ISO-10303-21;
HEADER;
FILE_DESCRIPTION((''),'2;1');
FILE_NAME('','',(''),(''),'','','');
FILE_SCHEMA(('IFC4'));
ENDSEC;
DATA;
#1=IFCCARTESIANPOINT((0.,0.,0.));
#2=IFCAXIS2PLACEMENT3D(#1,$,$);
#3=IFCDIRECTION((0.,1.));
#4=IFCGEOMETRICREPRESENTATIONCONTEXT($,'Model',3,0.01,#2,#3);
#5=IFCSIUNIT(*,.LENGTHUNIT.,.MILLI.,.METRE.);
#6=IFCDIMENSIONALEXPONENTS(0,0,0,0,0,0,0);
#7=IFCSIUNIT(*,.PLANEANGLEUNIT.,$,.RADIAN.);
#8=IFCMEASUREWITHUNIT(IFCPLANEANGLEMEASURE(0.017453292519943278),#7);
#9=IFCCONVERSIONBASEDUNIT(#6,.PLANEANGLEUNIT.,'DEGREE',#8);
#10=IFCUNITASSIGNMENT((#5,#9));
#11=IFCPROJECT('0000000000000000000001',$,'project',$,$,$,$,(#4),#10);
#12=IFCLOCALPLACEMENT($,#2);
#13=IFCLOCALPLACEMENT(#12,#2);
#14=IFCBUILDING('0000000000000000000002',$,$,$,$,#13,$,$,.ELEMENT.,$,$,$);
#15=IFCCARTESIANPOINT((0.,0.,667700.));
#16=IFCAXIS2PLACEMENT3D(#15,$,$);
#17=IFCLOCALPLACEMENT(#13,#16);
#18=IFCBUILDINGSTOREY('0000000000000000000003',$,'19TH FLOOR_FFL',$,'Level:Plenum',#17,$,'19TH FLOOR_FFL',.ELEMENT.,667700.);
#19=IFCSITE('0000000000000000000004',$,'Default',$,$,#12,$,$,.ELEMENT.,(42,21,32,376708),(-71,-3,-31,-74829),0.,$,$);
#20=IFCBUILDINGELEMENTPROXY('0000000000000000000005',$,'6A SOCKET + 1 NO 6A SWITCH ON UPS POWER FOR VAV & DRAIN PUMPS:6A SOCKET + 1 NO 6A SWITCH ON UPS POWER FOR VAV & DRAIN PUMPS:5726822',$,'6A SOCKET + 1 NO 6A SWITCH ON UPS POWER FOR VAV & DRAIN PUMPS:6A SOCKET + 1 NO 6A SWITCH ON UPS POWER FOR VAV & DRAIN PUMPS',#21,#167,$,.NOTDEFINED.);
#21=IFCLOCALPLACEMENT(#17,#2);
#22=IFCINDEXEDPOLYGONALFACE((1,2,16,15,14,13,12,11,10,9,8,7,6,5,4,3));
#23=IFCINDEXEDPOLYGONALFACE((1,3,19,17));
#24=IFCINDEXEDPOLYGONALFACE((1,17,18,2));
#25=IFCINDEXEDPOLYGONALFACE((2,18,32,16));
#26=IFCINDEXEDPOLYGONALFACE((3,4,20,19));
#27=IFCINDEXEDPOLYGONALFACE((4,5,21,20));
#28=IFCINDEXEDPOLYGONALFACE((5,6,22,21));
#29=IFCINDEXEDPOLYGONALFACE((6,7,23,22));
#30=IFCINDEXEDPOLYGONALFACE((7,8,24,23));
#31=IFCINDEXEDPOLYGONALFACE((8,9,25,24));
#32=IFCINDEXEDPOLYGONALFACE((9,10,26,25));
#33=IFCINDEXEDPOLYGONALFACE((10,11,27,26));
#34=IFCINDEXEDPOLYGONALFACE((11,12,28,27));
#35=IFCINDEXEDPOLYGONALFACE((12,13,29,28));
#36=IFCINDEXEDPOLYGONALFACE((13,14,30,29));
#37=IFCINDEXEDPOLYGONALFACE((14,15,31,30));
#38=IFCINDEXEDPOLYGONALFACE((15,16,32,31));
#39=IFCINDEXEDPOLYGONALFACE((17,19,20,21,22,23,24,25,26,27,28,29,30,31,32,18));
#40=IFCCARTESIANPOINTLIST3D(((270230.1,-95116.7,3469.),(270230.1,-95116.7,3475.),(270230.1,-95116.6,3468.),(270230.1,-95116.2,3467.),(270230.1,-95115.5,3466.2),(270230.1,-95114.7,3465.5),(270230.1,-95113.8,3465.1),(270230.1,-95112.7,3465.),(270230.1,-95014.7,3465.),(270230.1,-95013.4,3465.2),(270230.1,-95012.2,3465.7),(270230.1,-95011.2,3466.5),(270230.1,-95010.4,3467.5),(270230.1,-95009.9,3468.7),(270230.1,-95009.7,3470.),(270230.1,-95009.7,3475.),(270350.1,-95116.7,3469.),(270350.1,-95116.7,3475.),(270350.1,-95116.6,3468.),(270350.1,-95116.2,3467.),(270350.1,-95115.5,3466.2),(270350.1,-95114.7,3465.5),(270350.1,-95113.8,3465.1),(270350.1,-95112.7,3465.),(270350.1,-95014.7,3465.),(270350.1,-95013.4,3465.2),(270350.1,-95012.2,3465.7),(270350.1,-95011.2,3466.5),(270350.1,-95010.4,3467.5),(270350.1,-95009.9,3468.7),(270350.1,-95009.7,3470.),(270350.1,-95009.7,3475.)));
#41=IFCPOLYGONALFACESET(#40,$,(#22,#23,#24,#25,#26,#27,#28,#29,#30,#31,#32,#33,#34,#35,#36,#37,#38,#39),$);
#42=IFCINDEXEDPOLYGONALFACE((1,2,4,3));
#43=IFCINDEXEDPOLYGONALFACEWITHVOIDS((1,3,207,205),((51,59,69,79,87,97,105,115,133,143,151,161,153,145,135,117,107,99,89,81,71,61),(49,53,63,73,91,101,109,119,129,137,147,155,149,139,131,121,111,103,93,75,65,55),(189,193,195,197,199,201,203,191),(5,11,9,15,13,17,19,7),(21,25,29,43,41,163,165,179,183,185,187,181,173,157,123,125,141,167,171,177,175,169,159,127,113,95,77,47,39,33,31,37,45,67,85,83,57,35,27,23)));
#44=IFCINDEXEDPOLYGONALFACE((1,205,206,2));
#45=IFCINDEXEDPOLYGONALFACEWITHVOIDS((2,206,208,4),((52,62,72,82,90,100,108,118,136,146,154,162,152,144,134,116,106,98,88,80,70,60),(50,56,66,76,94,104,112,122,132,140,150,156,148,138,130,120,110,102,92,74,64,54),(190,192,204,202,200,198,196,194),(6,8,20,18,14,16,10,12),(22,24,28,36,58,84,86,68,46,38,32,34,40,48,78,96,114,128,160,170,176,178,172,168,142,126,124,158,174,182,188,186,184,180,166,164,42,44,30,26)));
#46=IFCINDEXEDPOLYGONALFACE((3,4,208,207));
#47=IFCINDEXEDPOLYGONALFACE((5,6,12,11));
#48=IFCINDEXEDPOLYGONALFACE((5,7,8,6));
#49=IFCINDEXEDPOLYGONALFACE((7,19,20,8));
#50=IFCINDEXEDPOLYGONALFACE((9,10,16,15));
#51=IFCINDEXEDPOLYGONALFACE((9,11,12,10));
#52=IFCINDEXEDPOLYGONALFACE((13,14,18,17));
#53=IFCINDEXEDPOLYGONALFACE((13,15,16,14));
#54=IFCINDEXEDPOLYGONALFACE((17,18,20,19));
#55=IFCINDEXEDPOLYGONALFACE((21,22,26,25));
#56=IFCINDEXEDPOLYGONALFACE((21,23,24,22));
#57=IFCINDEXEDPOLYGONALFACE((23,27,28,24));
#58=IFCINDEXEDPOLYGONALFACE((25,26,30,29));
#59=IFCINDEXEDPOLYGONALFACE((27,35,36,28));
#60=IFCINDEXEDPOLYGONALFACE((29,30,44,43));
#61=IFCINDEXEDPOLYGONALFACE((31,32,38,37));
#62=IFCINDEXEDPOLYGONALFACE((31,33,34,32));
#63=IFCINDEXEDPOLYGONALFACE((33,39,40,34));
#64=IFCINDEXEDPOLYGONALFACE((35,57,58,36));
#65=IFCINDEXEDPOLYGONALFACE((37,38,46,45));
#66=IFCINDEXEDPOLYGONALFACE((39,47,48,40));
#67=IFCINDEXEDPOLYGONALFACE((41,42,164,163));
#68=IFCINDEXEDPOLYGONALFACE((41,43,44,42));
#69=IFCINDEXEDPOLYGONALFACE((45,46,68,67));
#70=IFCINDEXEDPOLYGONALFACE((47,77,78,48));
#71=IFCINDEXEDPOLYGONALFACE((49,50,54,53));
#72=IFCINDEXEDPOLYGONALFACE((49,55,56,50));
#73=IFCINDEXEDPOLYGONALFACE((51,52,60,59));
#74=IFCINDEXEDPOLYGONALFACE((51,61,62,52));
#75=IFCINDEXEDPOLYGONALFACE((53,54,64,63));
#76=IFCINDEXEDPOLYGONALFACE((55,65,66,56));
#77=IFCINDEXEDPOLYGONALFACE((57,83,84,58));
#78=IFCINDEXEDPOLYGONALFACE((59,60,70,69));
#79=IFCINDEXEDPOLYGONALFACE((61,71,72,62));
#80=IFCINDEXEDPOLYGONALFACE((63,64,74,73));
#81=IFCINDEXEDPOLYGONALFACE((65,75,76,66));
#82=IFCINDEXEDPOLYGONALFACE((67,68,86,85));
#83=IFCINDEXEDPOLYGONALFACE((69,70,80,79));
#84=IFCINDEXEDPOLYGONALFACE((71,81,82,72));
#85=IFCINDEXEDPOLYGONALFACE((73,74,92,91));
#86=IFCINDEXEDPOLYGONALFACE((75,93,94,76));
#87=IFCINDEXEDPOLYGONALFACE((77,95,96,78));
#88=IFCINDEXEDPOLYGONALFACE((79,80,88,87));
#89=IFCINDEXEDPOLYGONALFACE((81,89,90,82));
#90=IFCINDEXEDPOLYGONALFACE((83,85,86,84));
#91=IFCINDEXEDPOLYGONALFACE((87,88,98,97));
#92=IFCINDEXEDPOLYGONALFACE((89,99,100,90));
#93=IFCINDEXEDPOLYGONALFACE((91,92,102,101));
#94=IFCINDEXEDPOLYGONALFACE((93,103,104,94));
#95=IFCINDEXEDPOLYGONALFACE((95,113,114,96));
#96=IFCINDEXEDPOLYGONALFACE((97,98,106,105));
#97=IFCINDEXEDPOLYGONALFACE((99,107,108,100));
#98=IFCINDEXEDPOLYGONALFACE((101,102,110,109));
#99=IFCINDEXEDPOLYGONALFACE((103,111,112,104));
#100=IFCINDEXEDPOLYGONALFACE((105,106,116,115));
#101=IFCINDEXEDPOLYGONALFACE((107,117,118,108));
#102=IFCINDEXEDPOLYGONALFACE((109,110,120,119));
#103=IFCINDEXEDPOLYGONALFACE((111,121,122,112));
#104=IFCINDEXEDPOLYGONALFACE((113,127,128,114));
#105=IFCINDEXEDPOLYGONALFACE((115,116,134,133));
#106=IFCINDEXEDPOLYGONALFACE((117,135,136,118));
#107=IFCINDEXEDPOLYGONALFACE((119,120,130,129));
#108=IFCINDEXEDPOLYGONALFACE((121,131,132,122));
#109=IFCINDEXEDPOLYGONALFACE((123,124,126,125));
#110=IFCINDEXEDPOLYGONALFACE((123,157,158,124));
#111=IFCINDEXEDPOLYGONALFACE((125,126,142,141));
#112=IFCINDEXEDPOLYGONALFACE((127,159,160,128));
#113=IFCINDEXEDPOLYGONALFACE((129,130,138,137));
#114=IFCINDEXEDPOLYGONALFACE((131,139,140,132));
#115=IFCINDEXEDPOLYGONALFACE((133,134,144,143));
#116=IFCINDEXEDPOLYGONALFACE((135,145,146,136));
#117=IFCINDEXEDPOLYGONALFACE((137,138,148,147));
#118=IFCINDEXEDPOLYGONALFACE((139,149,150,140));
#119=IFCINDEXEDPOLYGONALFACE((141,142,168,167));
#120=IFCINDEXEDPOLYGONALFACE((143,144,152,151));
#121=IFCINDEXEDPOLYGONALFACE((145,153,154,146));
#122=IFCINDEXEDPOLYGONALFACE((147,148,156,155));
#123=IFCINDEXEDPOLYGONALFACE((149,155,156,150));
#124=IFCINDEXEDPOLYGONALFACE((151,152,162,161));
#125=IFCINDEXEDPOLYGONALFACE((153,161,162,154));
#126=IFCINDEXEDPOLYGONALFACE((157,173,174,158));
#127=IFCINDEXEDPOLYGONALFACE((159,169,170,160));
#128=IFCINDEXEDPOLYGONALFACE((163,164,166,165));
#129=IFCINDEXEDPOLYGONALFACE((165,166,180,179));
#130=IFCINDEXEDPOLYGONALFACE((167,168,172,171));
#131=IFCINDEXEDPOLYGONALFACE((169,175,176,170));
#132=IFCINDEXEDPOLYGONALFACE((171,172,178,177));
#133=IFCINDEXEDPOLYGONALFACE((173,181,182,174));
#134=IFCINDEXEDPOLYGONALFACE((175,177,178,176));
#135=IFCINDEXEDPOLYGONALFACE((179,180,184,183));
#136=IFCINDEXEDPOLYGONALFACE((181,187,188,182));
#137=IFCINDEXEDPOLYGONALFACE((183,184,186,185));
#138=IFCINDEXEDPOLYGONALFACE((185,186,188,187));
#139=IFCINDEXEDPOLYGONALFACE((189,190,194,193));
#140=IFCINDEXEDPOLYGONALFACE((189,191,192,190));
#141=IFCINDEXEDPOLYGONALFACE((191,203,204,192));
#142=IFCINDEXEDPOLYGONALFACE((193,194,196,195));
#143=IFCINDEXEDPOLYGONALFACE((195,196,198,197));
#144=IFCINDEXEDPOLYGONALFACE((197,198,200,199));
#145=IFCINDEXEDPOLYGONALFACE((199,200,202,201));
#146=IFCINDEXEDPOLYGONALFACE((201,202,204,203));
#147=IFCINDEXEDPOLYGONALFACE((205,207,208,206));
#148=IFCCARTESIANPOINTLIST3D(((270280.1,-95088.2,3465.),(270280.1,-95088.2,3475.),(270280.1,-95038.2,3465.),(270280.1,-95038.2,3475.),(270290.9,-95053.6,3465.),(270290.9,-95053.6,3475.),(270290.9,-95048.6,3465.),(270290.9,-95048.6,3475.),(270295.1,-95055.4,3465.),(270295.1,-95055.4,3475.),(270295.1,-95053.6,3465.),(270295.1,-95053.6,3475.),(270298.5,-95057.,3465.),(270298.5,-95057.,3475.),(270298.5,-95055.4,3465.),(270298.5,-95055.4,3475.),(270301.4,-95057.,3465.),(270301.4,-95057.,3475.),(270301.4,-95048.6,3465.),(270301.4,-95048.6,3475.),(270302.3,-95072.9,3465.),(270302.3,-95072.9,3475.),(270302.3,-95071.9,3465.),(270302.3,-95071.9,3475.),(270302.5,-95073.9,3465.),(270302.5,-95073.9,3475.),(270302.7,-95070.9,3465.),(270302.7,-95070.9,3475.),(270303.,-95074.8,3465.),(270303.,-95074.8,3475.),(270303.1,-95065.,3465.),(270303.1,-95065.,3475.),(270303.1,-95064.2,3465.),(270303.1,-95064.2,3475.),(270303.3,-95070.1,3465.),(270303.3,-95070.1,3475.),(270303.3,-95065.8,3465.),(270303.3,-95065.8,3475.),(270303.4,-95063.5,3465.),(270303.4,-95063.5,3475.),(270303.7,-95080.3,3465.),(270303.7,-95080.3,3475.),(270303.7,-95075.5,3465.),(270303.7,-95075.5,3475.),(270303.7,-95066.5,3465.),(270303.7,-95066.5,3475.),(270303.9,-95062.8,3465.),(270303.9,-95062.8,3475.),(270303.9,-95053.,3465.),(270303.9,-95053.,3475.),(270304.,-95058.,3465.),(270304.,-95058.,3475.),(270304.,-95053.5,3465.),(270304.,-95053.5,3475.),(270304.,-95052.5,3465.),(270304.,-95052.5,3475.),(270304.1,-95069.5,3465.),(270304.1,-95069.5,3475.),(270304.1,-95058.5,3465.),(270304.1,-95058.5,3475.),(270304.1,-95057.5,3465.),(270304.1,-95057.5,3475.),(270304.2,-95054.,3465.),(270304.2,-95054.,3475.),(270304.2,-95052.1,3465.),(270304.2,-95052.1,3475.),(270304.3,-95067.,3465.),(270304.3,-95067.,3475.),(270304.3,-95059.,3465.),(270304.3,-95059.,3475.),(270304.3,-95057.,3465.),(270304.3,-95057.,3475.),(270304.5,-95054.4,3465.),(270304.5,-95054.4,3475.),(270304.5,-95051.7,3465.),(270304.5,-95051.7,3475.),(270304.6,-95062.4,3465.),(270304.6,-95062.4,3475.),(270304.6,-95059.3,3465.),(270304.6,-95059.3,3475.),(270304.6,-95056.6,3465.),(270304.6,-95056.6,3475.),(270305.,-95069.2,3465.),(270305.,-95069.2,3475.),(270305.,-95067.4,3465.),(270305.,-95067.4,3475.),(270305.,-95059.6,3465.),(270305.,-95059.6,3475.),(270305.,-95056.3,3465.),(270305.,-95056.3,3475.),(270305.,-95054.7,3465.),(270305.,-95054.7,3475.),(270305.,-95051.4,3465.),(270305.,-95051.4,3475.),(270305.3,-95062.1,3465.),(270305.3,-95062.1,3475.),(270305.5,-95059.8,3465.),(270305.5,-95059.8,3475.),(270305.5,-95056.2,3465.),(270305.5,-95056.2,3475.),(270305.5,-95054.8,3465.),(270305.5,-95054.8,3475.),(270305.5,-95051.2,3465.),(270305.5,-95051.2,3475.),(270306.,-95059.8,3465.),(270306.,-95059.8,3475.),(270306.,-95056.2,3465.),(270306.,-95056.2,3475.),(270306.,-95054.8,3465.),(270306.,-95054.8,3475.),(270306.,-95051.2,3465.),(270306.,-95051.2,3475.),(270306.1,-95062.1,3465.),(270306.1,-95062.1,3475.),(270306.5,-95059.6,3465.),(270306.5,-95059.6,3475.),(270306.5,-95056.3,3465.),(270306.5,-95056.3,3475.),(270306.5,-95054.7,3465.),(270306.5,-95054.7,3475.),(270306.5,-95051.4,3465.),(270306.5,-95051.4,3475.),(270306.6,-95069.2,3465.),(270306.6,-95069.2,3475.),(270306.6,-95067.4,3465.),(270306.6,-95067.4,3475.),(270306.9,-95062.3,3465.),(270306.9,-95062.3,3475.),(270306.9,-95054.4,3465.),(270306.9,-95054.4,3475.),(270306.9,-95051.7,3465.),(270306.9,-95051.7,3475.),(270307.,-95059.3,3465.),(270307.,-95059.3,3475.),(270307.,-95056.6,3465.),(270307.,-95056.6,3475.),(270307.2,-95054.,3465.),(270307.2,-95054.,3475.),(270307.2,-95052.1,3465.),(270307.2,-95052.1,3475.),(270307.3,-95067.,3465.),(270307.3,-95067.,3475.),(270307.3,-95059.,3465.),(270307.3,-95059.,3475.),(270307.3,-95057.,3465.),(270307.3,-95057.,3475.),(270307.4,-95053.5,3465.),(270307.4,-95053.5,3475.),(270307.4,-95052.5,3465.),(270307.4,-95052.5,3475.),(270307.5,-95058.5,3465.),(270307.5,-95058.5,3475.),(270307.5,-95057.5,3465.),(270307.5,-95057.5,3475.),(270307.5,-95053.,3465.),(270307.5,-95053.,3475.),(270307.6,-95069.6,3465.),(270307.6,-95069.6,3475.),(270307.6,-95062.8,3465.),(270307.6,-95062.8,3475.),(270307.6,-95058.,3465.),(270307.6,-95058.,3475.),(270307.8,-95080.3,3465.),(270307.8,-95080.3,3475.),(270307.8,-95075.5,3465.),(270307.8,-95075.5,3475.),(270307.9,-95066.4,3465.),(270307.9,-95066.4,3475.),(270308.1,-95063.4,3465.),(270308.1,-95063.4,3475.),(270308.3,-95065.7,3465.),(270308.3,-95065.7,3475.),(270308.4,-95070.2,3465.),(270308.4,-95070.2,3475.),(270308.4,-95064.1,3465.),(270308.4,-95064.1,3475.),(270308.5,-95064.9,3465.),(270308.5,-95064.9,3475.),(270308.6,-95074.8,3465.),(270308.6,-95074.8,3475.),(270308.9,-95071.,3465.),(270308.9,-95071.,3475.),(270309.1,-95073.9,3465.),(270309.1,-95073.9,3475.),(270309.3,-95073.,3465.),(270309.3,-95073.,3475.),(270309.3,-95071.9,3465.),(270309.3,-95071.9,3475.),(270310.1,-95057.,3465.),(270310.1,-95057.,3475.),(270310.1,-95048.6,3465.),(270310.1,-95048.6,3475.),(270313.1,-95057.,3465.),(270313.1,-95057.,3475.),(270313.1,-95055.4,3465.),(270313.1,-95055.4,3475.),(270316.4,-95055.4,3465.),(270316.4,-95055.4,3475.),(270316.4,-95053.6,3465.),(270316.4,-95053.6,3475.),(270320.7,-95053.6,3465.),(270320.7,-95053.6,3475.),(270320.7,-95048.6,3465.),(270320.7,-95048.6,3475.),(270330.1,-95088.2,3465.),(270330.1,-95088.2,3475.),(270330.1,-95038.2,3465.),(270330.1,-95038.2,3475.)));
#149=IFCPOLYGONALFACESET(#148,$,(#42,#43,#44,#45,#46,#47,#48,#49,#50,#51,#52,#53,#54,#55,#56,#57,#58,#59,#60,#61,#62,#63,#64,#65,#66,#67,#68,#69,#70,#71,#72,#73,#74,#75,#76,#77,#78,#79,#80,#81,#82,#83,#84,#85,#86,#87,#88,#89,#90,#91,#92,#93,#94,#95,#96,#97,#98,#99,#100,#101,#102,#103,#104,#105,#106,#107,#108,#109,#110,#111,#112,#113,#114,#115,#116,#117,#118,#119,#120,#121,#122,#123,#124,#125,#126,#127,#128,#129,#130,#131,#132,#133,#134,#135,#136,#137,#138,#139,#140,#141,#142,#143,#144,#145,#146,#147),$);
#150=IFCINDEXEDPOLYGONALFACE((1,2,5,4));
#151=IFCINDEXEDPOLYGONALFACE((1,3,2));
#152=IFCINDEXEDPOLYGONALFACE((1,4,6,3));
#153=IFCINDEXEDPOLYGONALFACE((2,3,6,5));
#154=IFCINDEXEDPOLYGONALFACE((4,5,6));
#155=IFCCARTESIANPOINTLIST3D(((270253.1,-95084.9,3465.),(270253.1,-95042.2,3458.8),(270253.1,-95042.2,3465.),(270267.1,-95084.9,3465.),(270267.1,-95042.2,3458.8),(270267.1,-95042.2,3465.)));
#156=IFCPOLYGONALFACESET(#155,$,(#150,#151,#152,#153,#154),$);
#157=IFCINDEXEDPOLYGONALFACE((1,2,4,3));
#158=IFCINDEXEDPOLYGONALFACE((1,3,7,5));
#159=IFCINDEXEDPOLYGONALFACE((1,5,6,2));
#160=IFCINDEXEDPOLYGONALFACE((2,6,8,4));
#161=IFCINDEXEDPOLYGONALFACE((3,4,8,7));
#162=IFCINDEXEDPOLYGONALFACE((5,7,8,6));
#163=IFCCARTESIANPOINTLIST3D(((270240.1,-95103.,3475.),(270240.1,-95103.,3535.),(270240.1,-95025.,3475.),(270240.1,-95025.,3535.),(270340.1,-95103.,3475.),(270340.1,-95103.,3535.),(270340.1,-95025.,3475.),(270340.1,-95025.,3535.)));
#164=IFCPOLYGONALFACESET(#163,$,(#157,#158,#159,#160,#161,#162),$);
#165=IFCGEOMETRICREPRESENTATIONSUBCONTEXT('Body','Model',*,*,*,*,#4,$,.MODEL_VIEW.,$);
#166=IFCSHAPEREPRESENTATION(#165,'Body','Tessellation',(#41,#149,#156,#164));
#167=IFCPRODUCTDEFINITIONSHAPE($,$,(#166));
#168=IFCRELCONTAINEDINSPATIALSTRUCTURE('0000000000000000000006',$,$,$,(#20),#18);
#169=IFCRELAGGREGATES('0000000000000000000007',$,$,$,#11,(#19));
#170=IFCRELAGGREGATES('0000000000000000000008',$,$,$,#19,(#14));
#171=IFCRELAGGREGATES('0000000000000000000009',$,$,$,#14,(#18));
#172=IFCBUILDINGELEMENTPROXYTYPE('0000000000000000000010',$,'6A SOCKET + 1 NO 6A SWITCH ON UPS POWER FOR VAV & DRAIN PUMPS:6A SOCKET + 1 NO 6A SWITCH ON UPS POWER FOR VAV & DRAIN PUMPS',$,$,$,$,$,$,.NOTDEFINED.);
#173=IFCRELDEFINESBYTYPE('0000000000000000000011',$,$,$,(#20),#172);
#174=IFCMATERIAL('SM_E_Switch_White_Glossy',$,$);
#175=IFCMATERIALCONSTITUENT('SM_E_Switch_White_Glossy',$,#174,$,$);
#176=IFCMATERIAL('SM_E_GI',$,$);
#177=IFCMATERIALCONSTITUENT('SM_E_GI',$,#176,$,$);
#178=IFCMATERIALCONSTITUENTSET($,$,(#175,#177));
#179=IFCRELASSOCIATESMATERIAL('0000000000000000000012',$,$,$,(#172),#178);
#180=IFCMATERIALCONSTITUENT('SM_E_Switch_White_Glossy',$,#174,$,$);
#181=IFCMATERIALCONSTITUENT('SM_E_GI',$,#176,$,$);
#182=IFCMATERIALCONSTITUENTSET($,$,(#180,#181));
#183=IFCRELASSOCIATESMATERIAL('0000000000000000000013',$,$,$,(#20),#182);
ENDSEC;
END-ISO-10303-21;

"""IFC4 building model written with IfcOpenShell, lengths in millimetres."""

from ifc_helpers import new_model, entity, si_unit, converted_unit, direction, frame, origin, place, context, subcontext, project, spatial, line, arc, indexed_curve, outline, extrude, source, transform, mapped, material, constituent, constituent_set, type_object, type_shapes, element, save


model = new_model("IFC4")

# Units and contexts
model_context = context("Model", 3, precision=0.01, world=origin(), true_north=direction((0.0, 1.0)))
body_context = subcontext(model_context, "Body", "Model", "MODEL_VIEW")
ifc_project = project(units=[si_unit("LENGTHUNIT", "METRE", prefix="MILLI"), converted_unit("PLANEANGLEUNIT", "DEGREE", entity("IfcPlaneAngleMeasure", 0.017453292519943278), si_unit("PLANEANGLEUNIT", "RADIAN"), dimensions=[0, 0, 0, 0, 0, 0, 0])], contexts=[model_context])

# Site, building, storey
site_placement = place(None, origin())
site = spatial("IfcSite", under=ifc_project, at=site_placement, Name="Default", CompositionType="ELEMENT", RefLatitude=(42, 21, 32, 376708), RefLongitude=(-71, -3, -31, -74829), RefElevation=0.0)
building_placement = place(site_placement, origin())
building = spatial("IfcBuilding", under=site, at=building_placement, CompositionType="ELEMENT")
storey_placement = place(building_placement, frame((0.0, 0.0, 667700.0)))
storey = spatial("IfcBuildingStorey", under=building, at=storey_placement, Name="19TH FLOOR_FFL", ObjectType="Level:Plenum", LongName="19TH FLOOR_FFL", CompositionType="ELEMENT", Elevation=667700.0)

# Building element proxy
ifc_material_1 = material(Name="SM_E_Switch_White_Glossy")
ifc_constituent_1 = constituent(ifc_material_1, Name="SM_E_Switch_White_Glossy")
ifc_material_2 = material(Name="SM_E_GI")
ifc_constituent_2 = constituent(ifc_material_2, Name="SM_E_GI")
ifc_constituent_set_1 = constituent_set(constituents=[ifc_constituent_1, ifc_constituent_2])
ifc_constituent_3 = constituent(ifc_material_1, Name="SM_E_Switch_White_Glossy")
ifc_constituent_4 = constituent(ifc_material_2, Name="SM_E_GI")
ifc_constituent_set_2 = constituent_set(constituents=[ifc_constituent_3, ifc_constituent_4])
building_element_proxy_type_1 = type_object("IfcBuildingElementProxyType", Name="6A SOCKET + 1 NO 6A SWITCH ON UPS POWER FOR VAV & DRAIN PUMPS:6A SOCKET + 1 NO 6A SWITCH ON UPS POWER FOR VAV & DRAIN PUMPS", PredefinedType="NOTDEFINED", material=ifc_constituent_set_2)
shared_shape_1 = source(origin(), body_context, "Body", "SweptSolid", [
    extrude(outline(indexed_curve([(-5.2, -53.7), (-0.2, -53.7), (3.4, -52.2), (4.8, -48.7), (4.8, 49.3), (3.7, 52.2), (0.8, 53.3), (-5.2, 53.3)], segments=[line(1, 2), arc(2, 3, 4), line(4, 5), arc(5, 6, 7), line(7, 8, 1)], self_intersect=False)), frame((-60.0, 53.3, 5.2), z_axis=(1.0, 0.0, 0.0), x_axis=(0.0, 0.0, 1.0)), (0.0, 0.0, 1.0), 120.0),
    extrude(outline(indexed_curve([(-25.0, -25.0), (25.0, -25.0), (25.0, 25.0), (-25.0, 25.0), (-25.0, -25.0)], self_intersect=False), holes=[indexed_curve([(-5.9, -0.1), (-8.7, -2.8), (-12.3, -1.4), (-17.1, -1.4), (-17.1, 2.7), (-12.3, 2.7), (-8.7, 4.1), (-6.0, 1.5), (-4.1, 1.5), (1.1, 0.6), (-4.2, -0.1)], segments=[arc(1, 2, 3), line(3, 4, 5, 6), arc(6, 7, 8), line(8, 9), arc(9, 10, 11), line(11, 1)], self_intersect=False), indexed_curve([(5.2, 2.4), (7.0, 0.6), (5.2, -1.2), (3.4, 0.6)], segments=[arc(1, 2, 3), arc(3, 4, 1)], self_intersect=False), indexed_curve([(10.2, 2.4), (12.0, 0.6), (10.2, -1.2), (8.4, 0.6)], segments=[arc(1, 2, 3), arc(3, 4, 1)], self_intersect=False), indexed_curve([(14.7, 15.6), (14.7, 5.0), (6.3, 5.0), (6.3, 7.9), (7.8, 7.9), (7.8, 11.3), (9.7, 11.3), (9.7, 15.6), (14.7, 15.6)], self_intersect=False), indexed_curve([(14.7, -14.3), (9.7, -14.3), (9.7, -10.0), (7.8, -10.0), (7.8, -6.6), (6.3, -6.6), (6.3, -3.7), (14.7, -3.7), (14.7, -14.3)], self_intersect=False)]), frame((-15.0, 53.5, 0.0), z_axis=(0.0, 0.0, 1.0), x_axis=(0.0, 1.0, 0.0)), (0.0, 0.0, 1.0), 10.0),
    extrude(outline(indexed_curve([(-14.7, -2.0), (28.5, -2.0), (-13.8, 4.1), (-14.7, -2.0)], self_intersect=False)), frame((23.0, 60.3, 12.1), z_axis=(1.0, 0.0, 0.0), x_axis=(0.0, -0.989716, -0.143046)), (0.0, 0.0, 1.0), 14.0),
    extrude(outline(indexed_curve([(-39.0, -50.0), (39.0, -50.0), (39.0, 50.0), (-39.0, 50.0), (-39.0, -50.0)], self_intersect=False)), frame((0.0, 52.8, -60.0), z_axis=(0.0, 0.0, 1.0), x_axis=(0.0, 1.0, 0.0)), (0.0, 0.0, 1.0), 60.0),
])
type_shapes(building_element_proxy_type_1, [shared_shape_1])
proxy_1_placement = place(storey_placement, frame((270290.1, -95116.7, 3475.0), z_axis=(0.0, 0.0, -1.0), x_axis=(-1.0, 0.0, 0.0)))
element("IfcBuildingElementProxy", 1, at=proxy_1_placement, inside=storey, type_object=building_element_proxy_type_1, material=ifc_constituent_set_1, Name="6A SOCKET + 1 NO 6A SWITCH ON UPS POWER FOR VAV & DRAIN PUMPS:6A SOCKET + 1 NO 6A SWITCH ON UPS POWER FOR VAV & DRAIN PUMPS:5726822", ObjectType="6A SOCKET + 1 NO 6A SWITCH ON UPS POWER FOR VAV & DRAIN PUMPS:6A SOCKET + 1 NO 6A SWITCH ON UPS POWER FOR VAV & DRAIN PUMPS", PredefinedType="NOTDEFINED", context=body_context, shape_type="MappedRepresentation", body=[
    mapped(shared_shape_1, transform((0.0, 0.0, 0.0), scale=1.0)),
])

save(model, "model.ifc")
